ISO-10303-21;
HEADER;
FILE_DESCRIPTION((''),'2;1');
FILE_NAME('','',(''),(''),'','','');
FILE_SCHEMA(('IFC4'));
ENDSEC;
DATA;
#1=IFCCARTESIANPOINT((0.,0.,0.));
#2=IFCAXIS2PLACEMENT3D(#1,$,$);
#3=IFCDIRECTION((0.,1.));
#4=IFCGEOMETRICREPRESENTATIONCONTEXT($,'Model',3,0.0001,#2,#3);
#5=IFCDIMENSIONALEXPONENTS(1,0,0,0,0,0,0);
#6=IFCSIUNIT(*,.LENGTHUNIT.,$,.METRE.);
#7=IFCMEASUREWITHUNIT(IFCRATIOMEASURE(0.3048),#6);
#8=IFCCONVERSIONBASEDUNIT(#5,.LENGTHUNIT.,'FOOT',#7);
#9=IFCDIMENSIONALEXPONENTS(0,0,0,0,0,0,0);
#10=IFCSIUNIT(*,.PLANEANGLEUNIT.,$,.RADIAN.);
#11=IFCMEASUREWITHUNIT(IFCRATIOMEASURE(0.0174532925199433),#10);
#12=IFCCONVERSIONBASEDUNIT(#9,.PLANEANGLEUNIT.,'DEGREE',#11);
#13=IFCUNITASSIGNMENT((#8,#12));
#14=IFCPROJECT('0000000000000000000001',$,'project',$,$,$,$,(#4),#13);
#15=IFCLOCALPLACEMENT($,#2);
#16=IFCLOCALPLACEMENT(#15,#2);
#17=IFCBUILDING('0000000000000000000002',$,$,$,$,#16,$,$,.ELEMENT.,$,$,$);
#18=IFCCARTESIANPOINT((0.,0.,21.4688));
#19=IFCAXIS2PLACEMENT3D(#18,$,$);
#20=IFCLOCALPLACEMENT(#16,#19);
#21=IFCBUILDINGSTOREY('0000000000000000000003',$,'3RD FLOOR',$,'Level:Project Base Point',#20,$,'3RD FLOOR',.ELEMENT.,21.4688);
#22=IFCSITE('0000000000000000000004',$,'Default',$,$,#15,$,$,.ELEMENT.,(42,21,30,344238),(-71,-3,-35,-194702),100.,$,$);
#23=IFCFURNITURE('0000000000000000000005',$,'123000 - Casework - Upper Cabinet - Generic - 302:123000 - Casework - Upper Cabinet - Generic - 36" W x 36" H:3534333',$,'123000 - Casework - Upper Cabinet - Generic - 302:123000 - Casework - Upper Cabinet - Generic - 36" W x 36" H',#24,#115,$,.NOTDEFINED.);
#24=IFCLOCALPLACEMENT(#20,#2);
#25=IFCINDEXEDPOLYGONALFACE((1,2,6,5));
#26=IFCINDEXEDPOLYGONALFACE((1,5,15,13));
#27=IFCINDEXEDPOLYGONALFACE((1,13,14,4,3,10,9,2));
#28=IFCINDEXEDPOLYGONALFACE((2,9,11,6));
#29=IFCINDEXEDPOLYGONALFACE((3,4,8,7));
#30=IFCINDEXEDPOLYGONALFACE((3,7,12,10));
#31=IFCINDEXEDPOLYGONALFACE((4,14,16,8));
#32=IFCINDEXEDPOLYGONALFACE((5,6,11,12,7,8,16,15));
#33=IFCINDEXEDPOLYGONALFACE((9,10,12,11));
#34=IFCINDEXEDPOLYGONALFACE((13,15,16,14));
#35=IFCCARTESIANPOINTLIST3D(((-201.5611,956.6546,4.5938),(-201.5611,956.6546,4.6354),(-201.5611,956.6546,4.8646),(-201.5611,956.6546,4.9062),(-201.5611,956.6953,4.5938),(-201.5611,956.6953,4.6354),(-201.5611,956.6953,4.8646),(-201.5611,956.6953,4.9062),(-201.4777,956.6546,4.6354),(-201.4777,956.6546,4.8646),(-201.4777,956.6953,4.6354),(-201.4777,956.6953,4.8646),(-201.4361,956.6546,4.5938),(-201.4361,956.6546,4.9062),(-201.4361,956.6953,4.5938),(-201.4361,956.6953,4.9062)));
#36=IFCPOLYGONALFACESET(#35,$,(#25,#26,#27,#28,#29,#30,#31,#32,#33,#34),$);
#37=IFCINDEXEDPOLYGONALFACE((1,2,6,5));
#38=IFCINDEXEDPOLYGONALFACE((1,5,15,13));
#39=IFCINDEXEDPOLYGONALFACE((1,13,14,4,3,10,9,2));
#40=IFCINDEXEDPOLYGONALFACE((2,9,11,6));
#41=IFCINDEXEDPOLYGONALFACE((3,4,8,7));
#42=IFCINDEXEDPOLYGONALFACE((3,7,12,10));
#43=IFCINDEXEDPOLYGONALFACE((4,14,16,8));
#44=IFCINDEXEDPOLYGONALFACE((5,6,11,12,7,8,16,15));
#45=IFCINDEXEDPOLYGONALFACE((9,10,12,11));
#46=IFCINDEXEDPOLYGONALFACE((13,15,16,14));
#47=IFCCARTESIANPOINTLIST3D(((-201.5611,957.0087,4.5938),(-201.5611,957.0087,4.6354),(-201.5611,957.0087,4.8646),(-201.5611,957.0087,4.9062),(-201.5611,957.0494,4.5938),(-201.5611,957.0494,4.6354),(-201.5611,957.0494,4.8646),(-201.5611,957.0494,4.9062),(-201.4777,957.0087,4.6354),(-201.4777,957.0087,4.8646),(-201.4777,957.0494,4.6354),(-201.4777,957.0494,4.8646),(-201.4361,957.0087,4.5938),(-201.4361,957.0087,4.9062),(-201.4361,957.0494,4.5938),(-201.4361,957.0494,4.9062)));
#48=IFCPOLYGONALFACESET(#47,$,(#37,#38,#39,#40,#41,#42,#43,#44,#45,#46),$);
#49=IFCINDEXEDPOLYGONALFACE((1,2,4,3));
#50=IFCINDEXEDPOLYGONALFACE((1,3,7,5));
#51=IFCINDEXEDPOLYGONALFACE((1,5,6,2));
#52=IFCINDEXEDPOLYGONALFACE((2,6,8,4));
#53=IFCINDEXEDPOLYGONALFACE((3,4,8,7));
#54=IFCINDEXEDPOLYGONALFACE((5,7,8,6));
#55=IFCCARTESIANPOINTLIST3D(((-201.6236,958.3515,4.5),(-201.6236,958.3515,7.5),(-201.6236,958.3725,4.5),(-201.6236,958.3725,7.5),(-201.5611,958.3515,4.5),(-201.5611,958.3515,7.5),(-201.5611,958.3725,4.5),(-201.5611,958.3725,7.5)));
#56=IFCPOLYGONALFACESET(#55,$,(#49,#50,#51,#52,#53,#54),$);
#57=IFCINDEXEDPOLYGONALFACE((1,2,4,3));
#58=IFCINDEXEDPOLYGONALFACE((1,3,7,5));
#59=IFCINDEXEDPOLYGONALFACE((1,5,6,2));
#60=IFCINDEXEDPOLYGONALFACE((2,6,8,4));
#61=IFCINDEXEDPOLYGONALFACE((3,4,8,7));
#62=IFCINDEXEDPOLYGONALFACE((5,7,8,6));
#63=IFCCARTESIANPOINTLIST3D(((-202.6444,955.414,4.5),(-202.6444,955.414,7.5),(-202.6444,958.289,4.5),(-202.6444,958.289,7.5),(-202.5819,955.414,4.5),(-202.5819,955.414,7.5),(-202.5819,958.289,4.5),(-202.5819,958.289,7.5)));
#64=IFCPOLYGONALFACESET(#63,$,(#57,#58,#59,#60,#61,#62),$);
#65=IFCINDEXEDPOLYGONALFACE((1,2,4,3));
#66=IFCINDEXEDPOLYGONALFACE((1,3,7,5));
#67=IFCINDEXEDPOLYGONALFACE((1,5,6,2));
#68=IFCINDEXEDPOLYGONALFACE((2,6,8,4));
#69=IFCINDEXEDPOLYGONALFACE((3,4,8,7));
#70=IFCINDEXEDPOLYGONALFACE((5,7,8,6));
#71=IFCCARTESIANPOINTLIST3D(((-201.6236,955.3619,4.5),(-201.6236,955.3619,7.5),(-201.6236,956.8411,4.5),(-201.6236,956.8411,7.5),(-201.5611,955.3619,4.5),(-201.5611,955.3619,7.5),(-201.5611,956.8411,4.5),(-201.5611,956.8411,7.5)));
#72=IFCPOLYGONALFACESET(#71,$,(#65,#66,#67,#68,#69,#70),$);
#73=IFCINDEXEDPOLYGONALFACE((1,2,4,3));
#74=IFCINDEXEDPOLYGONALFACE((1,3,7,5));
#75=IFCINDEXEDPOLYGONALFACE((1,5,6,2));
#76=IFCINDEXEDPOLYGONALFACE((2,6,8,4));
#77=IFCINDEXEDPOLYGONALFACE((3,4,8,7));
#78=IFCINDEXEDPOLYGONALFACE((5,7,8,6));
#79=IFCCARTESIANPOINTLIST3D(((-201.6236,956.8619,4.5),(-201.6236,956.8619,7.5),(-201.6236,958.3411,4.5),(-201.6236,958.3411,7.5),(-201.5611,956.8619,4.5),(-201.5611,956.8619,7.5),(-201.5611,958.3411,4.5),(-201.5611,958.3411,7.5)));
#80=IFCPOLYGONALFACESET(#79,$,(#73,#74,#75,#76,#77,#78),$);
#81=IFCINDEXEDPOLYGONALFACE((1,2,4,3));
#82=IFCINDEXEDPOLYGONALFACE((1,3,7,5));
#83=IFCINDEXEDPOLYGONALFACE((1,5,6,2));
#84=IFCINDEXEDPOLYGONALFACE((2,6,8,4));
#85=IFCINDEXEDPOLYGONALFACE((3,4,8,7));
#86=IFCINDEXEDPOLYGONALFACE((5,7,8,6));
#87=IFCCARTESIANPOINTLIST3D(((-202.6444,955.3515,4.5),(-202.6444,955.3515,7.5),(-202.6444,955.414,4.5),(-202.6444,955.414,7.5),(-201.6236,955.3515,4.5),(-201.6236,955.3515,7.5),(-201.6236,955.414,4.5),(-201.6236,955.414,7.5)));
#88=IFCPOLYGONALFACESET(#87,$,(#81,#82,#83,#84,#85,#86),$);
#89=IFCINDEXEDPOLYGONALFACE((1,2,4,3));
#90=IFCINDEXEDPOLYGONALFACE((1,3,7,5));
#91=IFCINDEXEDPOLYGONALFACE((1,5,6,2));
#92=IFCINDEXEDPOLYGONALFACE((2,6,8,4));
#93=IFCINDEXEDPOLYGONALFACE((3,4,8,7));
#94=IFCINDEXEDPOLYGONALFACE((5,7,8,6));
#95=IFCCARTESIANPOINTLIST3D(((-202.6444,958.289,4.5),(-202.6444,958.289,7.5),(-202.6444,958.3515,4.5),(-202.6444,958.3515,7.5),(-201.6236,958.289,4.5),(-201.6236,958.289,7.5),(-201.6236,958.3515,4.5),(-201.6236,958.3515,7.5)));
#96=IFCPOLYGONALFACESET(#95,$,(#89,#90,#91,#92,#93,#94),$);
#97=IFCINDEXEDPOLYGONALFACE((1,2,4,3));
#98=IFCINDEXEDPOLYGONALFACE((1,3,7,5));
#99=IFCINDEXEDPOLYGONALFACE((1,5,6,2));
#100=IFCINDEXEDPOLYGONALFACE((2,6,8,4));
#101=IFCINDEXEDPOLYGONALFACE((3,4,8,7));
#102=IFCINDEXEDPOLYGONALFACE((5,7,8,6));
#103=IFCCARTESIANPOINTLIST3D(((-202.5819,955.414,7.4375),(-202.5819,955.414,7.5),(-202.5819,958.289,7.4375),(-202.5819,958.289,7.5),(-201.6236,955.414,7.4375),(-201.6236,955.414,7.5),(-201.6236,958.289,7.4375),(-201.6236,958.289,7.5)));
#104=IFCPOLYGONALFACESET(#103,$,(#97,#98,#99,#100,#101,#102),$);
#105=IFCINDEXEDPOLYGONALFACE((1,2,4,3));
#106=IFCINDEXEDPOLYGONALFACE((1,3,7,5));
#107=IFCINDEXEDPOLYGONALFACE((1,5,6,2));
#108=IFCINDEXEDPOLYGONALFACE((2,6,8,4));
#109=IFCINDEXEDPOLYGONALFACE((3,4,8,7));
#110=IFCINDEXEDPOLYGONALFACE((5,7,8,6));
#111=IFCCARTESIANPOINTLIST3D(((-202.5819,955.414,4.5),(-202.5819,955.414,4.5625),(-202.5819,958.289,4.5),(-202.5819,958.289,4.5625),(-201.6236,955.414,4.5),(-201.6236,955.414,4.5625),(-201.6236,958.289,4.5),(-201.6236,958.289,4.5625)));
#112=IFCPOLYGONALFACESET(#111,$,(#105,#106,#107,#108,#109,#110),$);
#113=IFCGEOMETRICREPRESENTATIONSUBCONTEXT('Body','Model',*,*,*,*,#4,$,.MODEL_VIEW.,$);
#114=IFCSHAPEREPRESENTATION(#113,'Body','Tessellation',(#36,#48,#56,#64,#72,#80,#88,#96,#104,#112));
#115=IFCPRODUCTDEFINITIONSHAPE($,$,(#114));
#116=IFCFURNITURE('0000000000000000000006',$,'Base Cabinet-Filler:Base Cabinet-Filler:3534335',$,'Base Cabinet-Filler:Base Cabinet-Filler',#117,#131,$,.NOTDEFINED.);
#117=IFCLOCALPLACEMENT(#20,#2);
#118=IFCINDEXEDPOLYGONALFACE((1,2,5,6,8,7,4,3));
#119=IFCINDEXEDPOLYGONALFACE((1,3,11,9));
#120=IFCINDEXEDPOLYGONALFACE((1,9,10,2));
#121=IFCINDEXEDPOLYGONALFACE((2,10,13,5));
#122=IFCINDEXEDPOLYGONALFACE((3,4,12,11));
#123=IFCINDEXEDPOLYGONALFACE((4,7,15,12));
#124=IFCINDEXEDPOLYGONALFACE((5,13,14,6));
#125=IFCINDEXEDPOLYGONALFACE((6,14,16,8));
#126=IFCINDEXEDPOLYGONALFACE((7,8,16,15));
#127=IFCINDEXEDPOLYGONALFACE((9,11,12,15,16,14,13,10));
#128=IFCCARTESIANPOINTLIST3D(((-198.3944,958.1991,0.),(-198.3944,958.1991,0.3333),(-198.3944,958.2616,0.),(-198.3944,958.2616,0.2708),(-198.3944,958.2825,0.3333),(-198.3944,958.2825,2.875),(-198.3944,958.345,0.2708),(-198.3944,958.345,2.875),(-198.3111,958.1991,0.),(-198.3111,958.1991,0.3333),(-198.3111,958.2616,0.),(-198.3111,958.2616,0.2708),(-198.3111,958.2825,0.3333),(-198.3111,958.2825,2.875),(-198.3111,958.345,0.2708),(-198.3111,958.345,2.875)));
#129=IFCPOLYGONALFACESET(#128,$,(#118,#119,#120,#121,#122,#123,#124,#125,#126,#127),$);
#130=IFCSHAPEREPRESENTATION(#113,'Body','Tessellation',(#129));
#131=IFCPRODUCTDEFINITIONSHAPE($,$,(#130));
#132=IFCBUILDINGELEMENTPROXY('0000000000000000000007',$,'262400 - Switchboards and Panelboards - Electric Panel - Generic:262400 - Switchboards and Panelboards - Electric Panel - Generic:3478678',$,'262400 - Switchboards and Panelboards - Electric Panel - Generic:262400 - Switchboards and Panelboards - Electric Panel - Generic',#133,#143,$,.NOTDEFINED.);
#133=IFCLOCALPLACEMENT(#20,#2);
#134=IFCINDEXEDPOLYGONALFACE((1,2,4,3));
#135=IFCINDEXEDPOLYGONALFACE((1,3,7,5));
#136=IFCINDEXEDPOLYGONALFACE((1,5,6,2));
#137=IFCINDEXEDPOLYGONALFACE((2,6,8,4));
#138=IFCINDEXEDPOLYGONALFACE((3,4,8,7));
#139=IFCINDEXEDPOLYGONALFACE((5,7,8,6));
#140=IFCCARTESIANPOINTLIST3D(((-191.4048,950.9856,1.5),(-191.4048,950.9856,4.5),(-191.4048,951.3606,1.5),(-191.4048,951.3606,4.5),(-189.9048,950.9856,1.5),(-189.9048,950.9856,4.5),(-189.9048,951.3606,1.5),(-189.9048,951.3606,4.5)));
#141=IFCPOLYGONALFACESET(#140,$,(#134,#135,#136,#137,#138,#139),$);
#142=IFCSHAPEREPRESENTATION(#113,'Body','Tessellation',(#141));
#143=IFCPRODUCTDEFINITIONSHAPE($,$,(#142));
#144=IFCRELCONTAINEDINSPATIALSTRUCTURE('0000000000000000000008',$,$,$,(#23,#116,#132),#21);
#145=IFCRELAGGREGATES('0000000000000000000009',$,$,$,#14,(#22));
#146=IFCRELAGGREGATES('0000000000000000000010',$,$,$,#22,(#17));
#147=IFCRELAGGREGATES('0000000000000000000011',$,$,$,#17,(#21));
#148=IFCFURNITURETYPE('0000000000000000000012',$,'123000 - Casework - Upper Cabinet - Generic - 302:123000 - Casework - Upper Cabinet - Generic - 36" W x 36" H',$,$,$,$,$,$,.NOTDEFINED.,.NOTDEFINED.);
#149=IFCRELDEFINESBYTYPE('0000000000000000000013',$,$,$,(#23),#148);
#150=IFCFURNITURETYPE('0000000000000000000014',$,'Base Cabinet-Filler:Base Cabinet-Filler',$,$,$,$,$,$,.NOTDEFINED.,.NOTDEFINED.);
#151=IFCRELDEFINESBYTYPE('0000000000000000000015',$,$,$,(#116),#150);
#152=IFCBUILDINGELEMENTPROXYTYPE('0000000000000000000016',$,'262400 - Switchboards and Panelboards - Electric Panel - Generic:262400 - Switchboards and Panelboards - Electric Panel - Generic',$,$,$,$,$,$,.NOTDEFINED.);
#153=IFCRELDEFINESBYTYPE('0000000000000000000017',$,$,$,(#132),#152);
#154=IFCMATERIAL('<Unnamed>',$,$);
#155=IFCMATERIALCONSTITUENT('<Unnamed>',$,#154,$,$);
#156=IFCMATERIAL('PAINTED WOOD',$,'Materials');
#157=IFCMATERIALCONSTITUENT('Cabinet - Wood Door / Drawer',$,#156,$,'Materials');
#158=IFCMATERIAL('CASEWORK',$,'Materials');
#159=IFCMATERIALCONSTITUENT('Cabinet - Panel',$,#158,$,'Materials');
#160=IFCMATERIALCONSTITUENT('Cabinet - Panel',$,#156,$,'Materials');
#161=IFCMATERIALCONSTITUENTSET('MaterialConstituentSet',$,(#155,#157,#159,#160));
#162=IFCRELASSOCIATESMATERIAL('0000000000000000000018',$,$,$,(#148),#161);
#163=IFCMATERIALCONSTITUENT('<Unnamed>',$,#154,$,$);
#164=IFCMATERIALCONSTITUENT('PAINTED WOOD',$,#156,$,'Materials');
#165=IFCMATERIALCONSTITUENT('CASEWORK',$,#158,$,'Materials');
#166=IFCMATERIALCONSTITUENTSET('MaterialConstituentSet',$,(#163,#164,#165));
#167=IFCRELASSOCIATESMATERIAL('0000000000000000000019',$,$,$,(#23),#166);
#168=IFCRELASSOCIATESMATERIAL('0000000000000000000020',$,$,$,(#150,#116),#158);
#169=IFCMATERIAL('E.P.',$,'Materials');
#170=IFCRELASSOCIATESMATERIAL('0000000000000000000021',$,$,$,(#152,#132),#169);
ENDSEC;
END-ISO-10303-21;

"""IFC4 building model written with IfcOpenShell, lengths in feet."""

from ifc_helpers import new_model, entity, si_unit, converted_unit, direction, frame, frame_2d, origin, origin_2d_with_axis, place, context, subcontext, project, spatial, polyline, rectangle, outline, extrude, source, transform, mapped, material, constituent, constituent_set, type_object, type_shapes, element, save


model = new_model("IFC4")

# Units and contexts
model_context = context("Model", 3, precision=0.0001, world=origin(), true_north=direction((0.0, 1.0)))
body_context = subcontext(model_context, "Body", "Model", "MODEL_VIEW")
ifc_project = project(units=[converted_unit("LENGTHUNIT", "FOOT", entity("IfcRatioMeasure", 0.3048), si_unit("LENGTHUNIT", "METRE"), dimensions=[1, 0, 0, 0, 0, 0, 0]), converted_unit("PLANEANGLEUNIT", "DEGREE", entity("IfcRatioMeasure", 0.0174532925199433), si_unit("PLANEANGLEUNIT", "RADIAN"), dimensions=[0, 0, 0, 0, 0, 0, 0])], contexts=[model_context])

# Site, building, storey
site_placement = place(None, origin())
site = spatial("IfcSite", under=ifc_project, at=site_placement, Name="Default", CompositionType="ELEMENT", RefLatitude=(42, 21, 30, 344238), RefLongitude=(-71, -3, -35, -194702), RefElevation=100.0)
building_placement = place(site_placement, origin())
building = spatial("IfcBuilding", under=site, at=building_placement, CompositionType="ELEMENT")
storey_placement = place(building_placement, frame((0.0, 0.0, 21.4688)))
storey = spatial("IfcBuildingStorey", under=building, at=storey_placement, Name="3RD FLOOR", ObjectType="Level:Project Base Point", LongName="3RD FLOOR", CompositionType="ELEMENT", Elevation=21.4688)

# Furniture
ifc_material_1 = material(Name="PAINTED WOOD", Category="Materials")
ifc_material_2 = material(Name="CASEWORK", Category="Materials")
ifc_material_3 = material(Name="<Unnamed>")
ifc_constituent_1 = constituent(ifc_material_3, Name="<Unnamed>")
ifc_constituent_2 = constituent(ifc_material_1, Name="PAINTED WOOD", Category="Materials")
ifc_constituent_3 = constituent(ifc_material_2, Name="CASEWORK", Category="Materials")
ifc_constituent_set_1 = constituent_set(constituents=[ifc_constituent_1, ifc_constituent_2, ifc_constituent_3], Name="MaterialConstituentSet")
ifc_constituent_4 = constituent(ifc_material_3, Name="<Unnamed>")
ifc_constituent_5 = constituent(ifc_material_1, Name="Cabinet - Wood Door / Drawer", Category="Materials")
ifc_constituent_6 = constituent(ifc_material_2, Name="Cabinet - Panel", Category="Materials")
ifc_constituent_7 = constituent(ifc_material_1, Name="Cabinet - Panel", Category="Materials")
ifc_constituent_set_2 = constituent_set(constituents=[ifc_constituent_4, ifc_constituent_5, ifc_constituent_6, ifc_constituent_7], Name="MaterialConstituentSet")
furniture_type_1 = type_object("IfcFurnitureType", Name="123000 - Casework - Upper Cabinet - Generic - 302:123000 - Casework - Upper Cabinet - Generic - 36\" W x 36\" H", AssemblyPlace="NOTDEFINED", PredefinedType="NOTDEFINED", material=ifc_constituent_set_2)
shared_shape_1 = source(origin(), body_context, "Body", "SweptSolid", [
    extrude(outline(polyline([(0.1146, -0.0521), (0.1562, -0.0521), (0.1562, 0.0729), (-0.1562, 0.0729), (-0.1562, -0.0521), (-0.1146, -0.0521), (-0.1146, 0.0313), (0.1146, 0.0313), (0.1146, -0.0521)])), frame((1.303, 0.0729, 0.25), z_axis=(1.0, 0.0, 0.0), x_axis=(0.0, 0.0, 1.0)), (0.0, 0.0, 1.0), 0.0407),
    extrude(outline(polyline([(0.1146, -0.0521), (0.1562, -0.0521), (0.1562, 0.0729), (-0.1562, 0.0729), (-0.1562, -0.0521), (-0.1146, -0.0521), (-0.1146, 0.0313), (0.1146, 0.0313), (0.1146, -0.0521)])), frame((1.6572, 0.0729, 0.25), z_axis=(1.0, 0.0, 0.0), x_axis=(0.0, 0.0, 1.0)), (0.0, 0.0, 1.0), 0.0407),
    extrude(rectangle(XDim=0.0625, YDim=0.021, at=frame_2d((0.0, 0.0), x_axis=(1.0, 0.0))), frame((3.0105, 0.1562, 0.0), z_axis=(0.0, 0.0, 1.0), x_axis=(0.0, -1.0, 0.0)), (0.0, 0.0, 1.0), 3.0),
    extrude(rectangle(XDim=0.0625, YDim=2.875, at=origin_2d_with_axis()), frame((1.5, 1.177, 0.0), z_axis=(0.0, 0.0, 1.0), x_axis=(0.0, 1.0, 0.0)), (0.0, 0.0, 1.0), 3.0),
    extrude(rectangle(XDim=0.0625, YDim=1.4792, at=frame_2d((0.0, 0.0), x_axis=(1.0, 0.0))), frame((0.75, 0.1562, 0.0), z_axis=(0.0, 0.0, 1.0), x_axis=(0.0, -1.0, 0.0)), (0.0, 0.0, 1.0), 3.0),
    extrude(rectangle(XDim=0.0625, YDim=1.4792, at=origin_2d_with_axis()), frame((2.25, 0.1562, 0.0), z_axis=(0.0, 0.0, 1.0), x_axis=(0.0, -1.0, 0.0)), (0.0, 0.0, 1.0), 3.0),
    extrude(rectangle(XDim=0.0625, YDim=1.0208, at=origin_2d_with_axis()), frame((0.0312, 0.6979, 0.0), z_axis=(0.0, 0.0, 1.0), x_axis=(-1.0, 0.0, 0.0)), (0.0, 0.0, 1.0), 3.0),
    extrude(rectangle(XDim=0.0625, YDim=1.0208, at=origin_2d_with_axis()), frame((2.9688, 0.6979, 0.0), z_axis=(0.0, 0.0, 1.0), x_axis=(-1.0, 0.0, 0.0)), (0.0, 0.0, 1.0), 3.0),
    extrude(rectangle(XDim=2.875, YDim=0.9583, at=frame_2d((0.0, 0.0), x_axis=(1.0, 0.0))), frame((1.5, 0.6666, 2.9375), z_axis=(0.0, 0.0, 1.0), x_axis=(-1.0, 0.0, 0.0)), (0.0, 0.0, 1.0), 0.0625),
    extrude(rectangle(XDim=2.875, YDim=0.9583, at=frame_2d((0.0, 0.0), x_axis=(1.0, 0.0))), frame((1.5, 0.6666, 0.0), z_axis=(0.0, 0.0, 1.0), x_axis=(-1.0, 0.0, 0.0)), (0.0, 0.0, 1.0), 0.0625),
])
type_shapes(furniture_type_1, [shared_shape_1])
furniture_1_placement = place(storey_placement, frame((-201.4361, 955.3515, 4.5), z_axis=(0.0, 0.0, 1.0), x_axis=(0.0, 1.0, 0.0)))
element("IfcFurniture", 1, at=furniture_1_placement, inside=storey, type_object=furniture_type_1, material=ifc_constituent_set_1, Name="123000 - Casework - Upper Cabinet - Generic - 302:123000 - Casework - Upper Cabinet - Generic - 36\" W x 36\" H:3534333", ObjectType="123000 - Casework - Upper Cabinet - Generic - 302:123000 - Casework - Upper Cabinet - Generic - 36\" W x 36\" H", PredefinedType="NOTDEFINED", context=body_context, shape_type="MappedRepresentation", body=[
    mapped(shared_shape_1, transform((0.0, 0.0, 0.0), scale=1.0)),
])
furniture_type_2 = type_object("IfcFurnitureType", Name="Base Cabinet-Filler:Base Cabinet-Filler", AssemblyPlace="NOTDEFINED", PredefinedType="NOTDEFINED", material=ifc_material_2)
shared_shape_2 = source(origin(), body_context, "Body", "SweptSolid", [
    extrude(outline(polyline([(-0.0729, 0.599), (-0.0729, -2.0052), (-0.0104, -2.0052), (-0.0104, 0.5365), (0.0729, 0.5365), (0.0729, 0.8698), (0.0104, 0.8698), (0.0104, 0.599), (-0.0729, 0.599)])), frame((0.0, 0.0729, 0.8698), z_axis=(-1.0, 0.0, 0.0), x_axis=(0.0, 1.0, 0.0)), (0.0, 0.0, -1.0), 0.0833),
])
type_shapes(furniture_type_2, [shared_shape_2])
furniture_2_placement = place(storey_placement, frame((-198.3111, 958.345, 0.0), z_axis=(0.0, 0.0, 1.0), x_axis=(-1.0, 0.0, 0.0)))
element("IfcFurniture", 2, at=furniture_2_placement, inside=storey, type_object=furniture_type_2, material=ifc_material_2, Name="Base Cabinet-Filler:Base Cabinet-Filler:3534335", ObjectType="Base Cabinet-Filler:Base Cabinet-Filler", PredefinedType="NOTDEFINED", context=body_context, shape_type="MappedRepresentation", body=[
    mapped(shared_shape_2, transform((0.0, 0.0, 0.0), scale=1.0)),
])

# Building element proxy
ifc_material_4 = material(Name="E.P.", Category="Materials")
building_element_proxy_type_1 = type_object("IfcBuildingElementProxyType", Name="262400 - Switchboards and Panelboards - Electric Panel - Generic:262400 - Switchboards and Panelboards - Electric Panel - Generic", PredefinedType="NOTDEFINED", material=ifc_material_4)
shared_shape_3 = source(origin(), body_context, "Body", "SweptSolid", [
    extrude(rectangle(XDim=0.375, YDim=1.5, at=origin_2d_with_axis()), frame((0.75, 0.1875, 0.0), z_axis=(0.0, 0.0, 1.0), x_axis=(0.0, 1.0, 0.0)), (0.0, 0.0, 1.0), 3.0),
])
type_shapes(building_element_proxy_type_1, [shared_shape_3])
proxy_1_placement = place(storey_placement, frame((-191.4048, 950.9856, 1.5)))
element("IfcBuildingElementProxy", 3, at=proxy_1_placement, inside=storey, type_object=building_element_proxy_type_1, material=ifc_material_4, Name="262400 - Switchboards and Panelboards - Electric Panel - Generic:262400 - Switchboards and Panelboards - Electric Panel - Generic:3478678", ObjectType="262400 - Switchboards and Panelboards - Electric Panel - Generic:262400 - Switchboards and Panelboards - Electric Panel - Generic", PredefinedType="NOTDEFINED", context=body_context, shape_type="MappedRepresentation", body=[
    mapped(shared_shape_3, transform((0.0, 0.0, 0.0), scale=1.0)),
])

save(model, "model.ifc")
